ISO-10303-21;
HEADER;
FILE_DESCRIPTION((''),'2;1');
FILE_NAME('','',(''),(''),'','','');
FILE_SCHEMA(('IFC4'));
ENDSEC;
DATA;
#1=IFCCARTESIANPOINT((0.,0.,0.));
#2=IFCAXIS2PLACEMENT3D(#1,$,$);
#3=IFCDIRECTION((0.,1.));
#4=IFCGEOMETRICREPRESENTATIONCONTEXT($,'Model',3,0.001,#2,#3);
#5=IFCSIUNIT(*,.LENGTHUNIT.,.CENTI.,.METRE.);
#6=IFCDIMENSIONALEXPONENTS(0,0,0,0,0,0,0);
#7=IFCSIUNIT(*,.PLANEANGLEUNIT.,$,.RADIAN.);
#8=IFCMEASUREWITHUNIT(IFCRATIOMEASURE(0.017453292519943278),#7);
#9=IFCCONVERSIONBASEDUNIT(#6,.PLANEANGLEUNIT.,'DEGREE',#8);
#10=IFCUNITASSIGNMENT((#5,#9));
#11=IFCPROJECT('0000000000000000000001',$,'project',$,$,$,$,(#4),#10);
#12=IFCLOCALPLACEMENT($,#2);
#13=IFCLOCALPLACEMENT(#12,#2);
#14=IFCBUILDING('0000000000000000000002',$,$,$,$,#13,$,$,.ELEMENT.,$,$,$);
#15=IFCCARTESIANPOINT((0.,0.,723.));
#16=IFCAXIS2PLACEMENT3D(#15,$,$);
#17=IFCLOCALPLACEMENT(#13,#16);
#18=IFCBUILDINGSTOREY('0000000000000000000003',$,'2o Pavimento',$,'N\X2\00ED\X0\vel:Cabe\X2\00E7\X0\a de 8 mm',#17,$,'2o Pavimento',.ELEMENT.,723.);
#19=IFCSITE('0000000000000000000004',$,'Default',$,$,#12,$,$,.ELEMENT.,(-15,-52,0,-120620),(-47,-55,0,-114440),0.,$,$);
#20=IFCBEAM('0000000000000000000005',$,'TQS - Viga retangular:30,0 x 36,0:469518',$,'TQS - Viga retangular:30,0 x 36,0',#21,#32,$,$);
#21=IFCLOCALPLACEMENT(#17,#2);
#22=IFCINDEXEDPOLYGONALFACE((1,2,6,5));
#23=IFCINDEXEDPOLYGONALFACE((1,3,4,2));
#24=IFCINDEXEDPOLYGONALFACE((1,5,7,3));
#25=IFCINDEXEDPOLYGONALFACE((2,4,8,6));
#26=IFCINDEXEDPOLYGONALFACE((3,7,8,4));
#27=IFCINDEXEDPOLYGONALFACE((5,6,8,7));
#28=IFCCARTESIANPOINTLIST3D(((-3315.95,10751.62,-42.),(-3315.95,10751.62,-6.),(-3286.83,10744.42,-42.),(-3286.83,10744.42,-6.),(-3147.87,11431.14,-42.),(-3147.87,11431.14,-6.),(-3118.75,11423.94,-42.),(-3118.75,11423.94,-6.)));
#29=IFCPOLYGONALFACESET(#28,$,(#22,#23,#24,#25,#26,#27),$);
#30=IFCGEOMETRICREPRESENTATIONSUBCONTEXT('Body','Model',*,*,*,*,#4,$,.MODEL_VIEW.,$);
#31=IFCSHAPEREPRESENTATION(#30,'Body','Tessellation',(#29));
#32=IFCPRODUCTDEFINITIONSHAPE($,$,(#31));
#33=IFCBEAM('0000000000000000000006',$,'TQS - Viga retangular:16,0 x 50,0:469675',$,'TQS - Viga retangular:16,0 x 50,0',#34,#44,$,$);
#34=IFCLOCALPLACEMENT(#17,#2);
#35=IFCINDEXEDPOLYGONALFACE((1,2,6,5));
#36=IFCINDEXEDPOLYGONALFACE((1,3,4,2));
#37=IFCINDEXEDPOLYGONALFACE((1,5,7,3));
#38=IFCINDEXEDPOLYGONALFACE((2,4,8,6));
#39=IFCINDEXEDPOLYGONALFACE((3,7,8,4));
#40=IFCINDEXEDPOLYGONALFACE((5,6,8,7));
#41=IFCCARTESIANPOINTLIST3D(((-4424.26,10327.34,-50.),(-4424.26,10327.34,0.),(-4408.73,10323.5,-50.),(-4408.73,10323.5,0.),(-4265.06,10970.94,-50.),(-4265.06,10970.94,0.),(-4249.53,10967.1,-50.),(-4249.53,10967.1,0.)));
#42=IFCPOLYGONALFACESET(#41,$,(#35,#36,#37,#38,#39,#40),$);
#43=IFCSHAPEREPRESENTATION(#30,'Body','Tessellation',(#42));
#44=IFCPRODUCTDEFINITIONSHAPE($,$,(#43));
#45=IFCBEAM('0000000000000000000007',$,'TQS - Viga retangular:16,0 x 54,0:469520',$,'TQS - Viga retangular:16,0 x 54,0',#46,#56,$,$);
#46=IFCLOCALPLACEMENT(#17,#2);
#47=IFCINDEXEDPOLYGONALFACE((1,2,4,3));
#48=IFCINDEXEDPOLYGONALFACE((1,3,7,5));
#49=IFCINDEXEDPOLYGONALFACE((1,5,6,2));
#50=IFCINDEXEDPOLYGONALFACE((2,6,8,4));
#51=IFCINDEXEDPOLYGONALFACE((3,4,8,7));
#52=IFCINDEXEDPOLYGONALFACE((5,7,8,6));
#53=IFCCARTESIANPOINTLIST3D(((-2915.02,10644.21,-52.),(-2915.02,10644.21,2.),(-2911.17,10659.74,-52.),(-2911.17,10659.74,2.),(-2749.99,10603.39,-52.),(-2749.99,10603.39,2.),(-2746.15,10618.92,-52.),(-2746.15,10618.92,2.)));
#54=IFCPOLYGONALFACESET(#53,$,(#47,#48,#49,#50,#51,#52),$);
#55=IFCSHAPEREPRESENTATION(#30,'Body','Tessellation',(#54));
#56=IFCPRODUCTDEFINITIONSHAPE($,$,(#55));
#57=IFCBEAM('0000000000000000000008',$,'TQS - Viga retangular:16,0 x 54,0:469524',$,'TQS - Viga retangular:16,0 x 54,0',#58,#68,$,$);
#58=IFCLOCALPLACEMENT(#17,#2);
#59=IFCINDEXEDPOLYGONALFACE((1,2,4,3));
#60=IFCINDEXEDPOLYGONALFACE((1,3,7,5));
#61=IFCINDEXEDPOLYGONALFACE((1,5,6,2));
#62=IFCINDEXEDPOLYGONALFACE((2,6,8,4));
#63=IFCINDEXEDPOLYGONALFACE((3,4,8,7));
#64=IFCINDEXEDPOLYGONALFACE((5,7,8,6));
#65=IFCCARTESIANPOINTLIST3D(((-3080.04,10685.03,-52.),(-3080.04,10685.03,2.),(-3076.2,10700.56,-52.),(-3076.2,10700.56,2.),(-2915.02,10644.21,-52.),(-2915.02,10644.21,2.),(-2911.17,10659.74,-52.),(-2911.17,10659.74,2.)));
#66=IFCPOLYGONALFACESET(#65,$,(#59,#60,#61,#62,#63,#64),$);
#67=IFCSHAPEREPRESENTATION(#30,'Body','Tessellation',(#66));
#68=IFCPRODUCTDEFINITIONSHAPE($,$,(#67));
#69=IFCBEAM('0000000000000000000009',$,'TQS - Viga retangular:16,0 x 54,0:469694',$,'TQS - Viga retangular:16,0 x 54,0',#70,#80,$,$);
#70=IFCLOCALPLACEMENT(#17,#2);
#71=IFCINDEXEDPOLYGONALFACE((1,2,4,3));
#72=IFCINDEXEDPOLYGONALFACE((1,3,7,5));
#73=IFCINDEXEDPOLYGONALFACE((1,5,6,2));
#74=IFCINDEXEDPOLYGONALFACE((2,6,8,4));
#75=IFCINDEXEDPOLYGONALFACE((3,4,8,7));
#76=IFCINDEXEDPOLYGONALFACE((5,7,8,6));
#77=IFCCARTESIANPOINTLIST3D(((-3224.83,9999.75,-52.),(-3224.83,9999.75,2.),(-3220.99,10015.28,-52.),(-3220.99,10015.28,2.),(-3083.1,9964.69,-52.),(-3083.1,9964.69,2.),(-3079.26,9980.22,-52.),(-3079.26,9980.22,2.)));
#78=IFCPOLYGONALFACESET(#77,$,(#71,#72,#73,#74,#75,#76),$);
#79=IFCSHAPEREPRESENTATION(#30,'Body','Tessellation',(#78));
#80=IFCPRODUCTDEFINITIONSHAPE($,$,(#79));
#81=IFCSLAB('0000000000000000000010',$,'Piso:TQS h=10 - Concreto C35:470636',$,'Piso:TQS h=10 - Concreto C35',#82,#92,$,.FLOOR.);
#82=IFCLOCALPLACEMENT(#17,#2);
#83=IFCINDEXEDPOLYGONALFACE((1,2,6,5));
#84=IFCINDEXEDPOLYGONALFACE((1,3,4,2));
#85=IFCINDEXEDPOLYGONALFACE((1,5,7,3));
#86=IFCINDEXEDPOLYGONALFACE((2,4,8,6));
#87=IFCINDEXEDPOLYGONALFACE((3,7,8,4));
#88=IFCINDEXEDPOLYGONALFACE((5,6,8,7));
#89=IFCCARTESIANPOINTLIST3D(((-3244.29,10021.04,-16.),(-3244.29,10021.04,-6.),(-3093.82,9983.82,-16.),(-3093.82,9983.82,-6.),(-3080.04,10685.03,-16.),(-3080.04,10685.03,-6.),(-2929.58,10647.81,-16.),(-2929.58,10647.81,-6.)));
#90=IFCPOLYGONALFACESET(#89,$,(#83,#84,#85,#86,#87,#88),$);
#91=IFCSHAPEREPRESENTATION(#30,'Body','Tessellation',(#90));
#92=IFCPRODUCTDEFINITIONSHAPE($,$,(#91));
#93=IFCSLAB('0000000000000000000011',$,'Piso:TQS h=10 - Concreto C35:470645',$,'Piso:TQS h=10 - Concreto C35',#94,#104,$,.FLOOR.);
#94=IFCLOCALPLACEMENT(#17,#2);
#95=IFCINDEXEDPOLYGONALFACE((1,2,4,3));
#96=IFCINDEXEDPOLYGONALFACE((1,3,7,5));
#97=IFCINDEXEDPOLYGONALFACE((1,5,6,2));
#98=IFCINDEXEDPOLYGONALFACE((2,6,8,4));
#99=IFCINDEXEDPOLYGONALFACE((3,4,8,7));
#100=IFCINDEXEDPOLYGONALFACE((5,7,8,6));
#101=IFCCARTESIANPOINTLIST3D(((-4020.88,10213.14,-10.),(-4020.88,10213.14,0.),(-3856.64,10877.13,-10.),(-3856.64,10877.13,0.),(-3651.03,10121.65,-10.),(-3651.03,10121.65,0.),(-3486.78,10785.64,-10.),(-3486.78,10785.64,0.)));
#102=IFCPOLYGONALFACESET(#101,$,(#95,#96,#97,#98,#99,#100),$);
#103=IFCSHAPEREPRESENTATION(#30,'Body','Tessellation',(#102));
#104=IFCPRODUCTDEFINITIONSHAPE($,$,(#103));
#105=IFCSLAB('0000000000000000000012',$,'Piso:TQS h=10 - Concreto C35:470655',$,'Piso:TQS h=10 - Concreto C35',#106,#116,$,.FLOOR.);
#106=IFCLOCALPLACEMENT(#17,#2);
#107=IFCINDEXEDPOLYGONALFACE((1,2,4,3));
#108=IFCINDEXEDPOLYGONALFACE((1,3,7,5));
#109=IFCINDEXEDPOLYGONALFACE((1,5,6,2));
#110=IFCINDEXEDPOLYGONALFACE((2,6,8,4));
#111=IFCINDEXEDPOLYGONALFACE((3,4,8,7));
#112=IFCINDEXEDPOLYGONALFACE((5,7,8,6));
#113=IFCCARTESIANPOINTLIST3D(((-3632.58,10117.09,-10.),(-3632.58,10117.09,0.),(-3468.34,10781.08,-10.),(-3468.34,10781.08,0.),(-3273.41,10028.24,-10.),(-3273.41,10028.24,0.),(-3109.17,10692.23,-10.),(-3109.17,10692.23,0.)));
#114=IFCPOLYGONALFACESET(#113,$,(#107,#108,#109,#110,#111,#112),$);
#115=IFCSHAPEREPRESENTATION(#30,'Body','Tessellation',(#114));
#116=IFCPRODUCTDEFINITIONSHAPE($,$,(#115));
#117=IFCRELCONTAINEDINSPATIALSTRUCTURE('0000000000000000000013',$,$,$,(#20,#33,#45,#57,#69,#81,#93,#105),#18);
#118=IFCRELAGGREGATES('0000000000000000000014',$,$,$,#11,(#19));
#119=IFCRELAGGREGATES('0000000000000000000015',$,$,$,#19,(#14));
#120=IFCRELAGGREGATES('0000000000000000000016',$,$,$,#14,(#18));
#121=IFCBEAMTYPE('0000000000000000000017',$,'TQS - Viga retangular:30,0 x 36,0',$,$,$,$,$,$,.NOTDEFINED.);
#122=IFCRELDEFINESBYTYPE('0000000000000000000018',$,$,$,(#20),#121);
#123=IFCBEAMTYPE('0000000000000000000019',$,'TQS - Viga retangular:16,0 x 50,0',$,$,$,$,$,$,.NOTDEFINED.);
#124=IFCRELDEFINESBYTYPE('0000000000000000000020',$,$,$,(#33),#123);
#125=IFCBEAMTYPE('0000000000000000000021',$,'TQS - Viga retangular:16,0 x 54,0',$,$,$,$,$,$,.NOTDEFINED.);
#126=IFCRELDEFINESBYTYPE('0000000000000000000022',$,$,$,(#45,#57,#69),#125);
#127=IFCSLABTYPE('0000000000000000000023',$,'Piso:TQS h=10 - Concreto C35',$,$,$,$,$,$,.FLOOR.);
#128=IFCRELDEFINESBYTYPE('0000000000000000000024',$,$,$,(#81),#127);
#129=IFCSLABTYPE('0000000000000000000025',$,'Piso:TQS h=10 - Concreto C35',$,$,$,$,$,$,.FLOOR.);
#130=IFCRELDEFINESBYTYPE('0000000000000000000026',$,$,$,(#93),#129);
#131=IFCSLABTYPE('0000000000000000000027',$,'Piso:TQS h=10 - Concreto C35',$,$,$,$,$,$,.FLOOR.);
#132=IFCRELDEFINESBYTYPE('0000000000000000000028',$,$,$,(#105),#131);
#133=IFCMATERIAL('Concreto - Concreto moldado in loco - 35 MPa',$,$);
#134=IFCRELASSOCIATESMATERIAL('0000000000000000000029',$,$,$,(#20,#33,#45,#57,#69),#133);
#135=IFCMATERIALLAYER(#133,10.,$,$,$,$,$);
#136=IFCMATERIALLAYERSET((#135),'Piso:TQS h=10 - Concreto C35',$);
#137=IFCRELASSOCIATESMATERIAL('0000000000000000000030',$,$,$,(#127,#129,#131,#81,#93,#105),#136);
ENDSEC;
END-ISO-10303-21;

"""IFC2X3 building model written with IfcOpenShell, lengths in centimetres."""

from ifc_helpers import new_model, entity, si_unit, converted_unit, direction, frame, frame_2d, origin, place, context, subcontext, project, spatial, rectangle, extrude, material, layer, layer_set, layer_usage, type_object, element, save


model = new_model("IFC2X3")

# Units and contexts
model_context = context("Model", 3, precision=0.001, world=origin(), true_north=direction((0.0, 1.0)))
body_context = subcontext(model_context, "Body", "Model", "MODEL_VIEW")
ifc_project = project(units=[si_unit("LENGTHUNIT", "METRE", prefix="CENTI"), converted_unit("PLANEANGLEUNIT", "DEGREE", entity("IfcRatioMeasure", 0.017453292519943278), si_unit("PLANEANGLEUNIT", "RADIAN"), dimensions=[0, 0, 0, 0, 0, 0, 0])], contexts=[model_context])

# Site, building, storey
site_placement = place(None, origin())
site = spatial("IfcSite", under=ifc_project, at=site_placement, Name="Default", CompositionType="ELEMENT", RefLatitude=(-15, -52, 0, -120620), RefLongitude=(-47, -55, 0, -114440), RefElevation=0.0)
building_placement = place(site_placement, origin())
building = spatial("IfcBuilding", under=site, at=building_placement, CompositionType="ELEMENT")
storey_placement = place(building_placement, frame((0.0, 0.0, 723.0)))
storey = spatial("IfcBuildingStorey", under=building, at=storey_placement, Name="2o Pavimento", ObjectType="Nível:Cabeça de 8 mm", LongName="2o Pavimento", CompositionType="ELEMENT", Elevation=723.0)

# Beams
ifc_material = material(Name="Concreto - Concreto moldado in loco - 35 MPa")
beam_type_1 = type_object("IfcBeamType", Name="TQS - Viga retangular:30,0 x 36,0", PredefinedType="NOTDEFINED")
beam_1_placement = place(storey_placement, frame((-3301.39, 10748.02, -6.0), z_axis=(0.0, 0.0, 1.0), x_axis=(0.240122, 0.970743, 0.0)))
element("IfcBeam", 1, at=beam_1_placement, inside=storey, type_object=beam_type_1, material=ifc_material, Name="TQS - Viga retangular:30,0 x 36,0:469518", ObjectType="TQS - Viga retangular:30,0 x 36,0", context=body_context, shape_type="SweptSolid", body=[
    extrude(rectangle(XDim=36.0, YDim=30.0, at=frame_2d((0.0, 0.0), x_axis=(1.0, 0.0))), frame((0.0, 0.0, -18.0), z_axis=(1.0, 0.0, 0.0), x_axis=(0.0, 0.0, -1.0)), (0.0, 0.0, 1.0), 700.0),
])
beam_type_2 = type_object("IfcBeamType", Name="TQS - Viga retangular:16,0 x 50,0", PredefinedType="NOTDEFINED")
beam_2_placement = place(storey_placement, frame((-4416.49, 10325.42, 0.0), z_axis=(0.0, 0.0, 1.0), x_axis=(0.240122, 0.970743, 0.0)))
element("IfcBeam", 2, at=beam_2_placement, inside=storey, type_object=beam_type_2, material=ifc_material, Name="TQS - Viga retangular:16,0 x 50,0:469675", ObjectType="TQS - Viga retangular:16,0 x 50,0", context=body_context, shape_type="SweptSolid", body=[
    extrude(rectangle(XDim=50.0, YDim=16.0, at=frame_2d((0.0, 0.0), x_axis=(1.0, 0.0))), frame((0.0, 0.0, -25.0), z_axis=(1.0, 0.0, 0.0), x_axis=(0.0, 0.0, -1.0)), (0.0, 0.0, 1.0), 663.0),
])
beam_type_3 = type_object("IfcBeamType", Name="TQS - Viga retangular:16,0 x 54,0", PredefinedType="NOTDEFINED")
beam_3_placement = place(storey_placement, frame((-2748.07, 10611.15, 2.0), z_axis=(0.0, 0.0, 1.0), x_axis=(-0.970743, 0.240122, 0.0)))
element("IfcBeam", 3, at=beam_3_placement, inside=storey, type_object=beam_type_3, material=ifc_material, Name="TQS - Viga retangular:16,0 x 54,0:469520", ObjectType="TQS - Viga retangular:16,0 x 54,0", context=body_context, shape_type="SweptSolid", body=[
    extrude(rectangle(XDim=54.0, YDim=16.0, at=frame_2d((0.0, 0.0), x_axis=(1.0, 0.0))), frame((0.0, 0.0, -27.0), z_axis=(1.0, 0.0, 0.0), x_axis=(0.0, 0.0, -1.0)), (0.0, 0.0, 1.0), 170.0),
])
beam_4_placement = place(storey_placement, frame((-2913.1, 10651.97, 2.0), z_axis=(0.0, 0.0, 1.0), x_axis=(-0.970743, 0.240122, 0.0)))
element("IfcBeam", 4, at=beam_4_placement, inside=storey, type_object=beam_type_3, material=ifc_material, Name="TQS - Viga retangular:16,0 x 54,0:469524", ObjectType="TQS - Viga retangular:16,0 x 54,0", context=body_context, shape_type="SweptSolid", body=[
    extrude(rectangle(XDim=54.0, YDim=16.0, at=frame_2d((0.0, 0.0), x_axis=(1.0, 0.0))), frame((0.0, 0.0, -27.0), z_axis=(1.0, 0.0, 0.0), x_axis=(0.0, 0.0, -1.0)), (0.0, 0.0, 1.0), 170.0),
])
beam_5_placement = place(storey_placement, frame((-3081.18, 9972.45, 2.0), z_axis=(0.0, 0.0, 1.0), x_axis=(-0.970743, 0.240122, 0.0)))
element("IfcBeam", 5, at=beam_5_placement, inside=storey, type_object=beam_type_3, material=ifc_material, Name="TQS - Viga retangular:16,0 x 54,0:469694", ObjectType="TQS - Viga retangular:16,0 x 54,0", context=body_context, shape_type="SweptSolid", body=[
    extrude(rectangle(XDim=54.0, YDim=16.0, at=frame_2d((0.0, 0.0), x_axis=(1.0, 0.0))), frame((0.0, 0.0, -27.0), z_axis=(1.0, 0.0, 0.0), x_axis=(0.0, 0.0, -1.0)), (0.0, 0.0, 1.0), 146.0),
])

# Slabs
ifc_layer = layer(ifc_material, 10.0)
ifc_layer_set = layer_set([ifc_layer], Name="Piso:TQS h=10 - Concreto C35")
ifc_layer_usage_1 = layer_usage(ifc_layer_set, "AXIS3", "POSITIVE", 0.0)
slab_type_1 = type_object("IfcSlabType", Name="Piso:TQS h=10 - Concreto C35", PredefinedType="FLOOR", material=ifc_layer_set)
slab_1_placement = place(storey_placement, origin())
element("IfcSlab", 6, at=slab_1_placement, inside=storey, type_object=slab_type_1, material=ifc_layer_usage_1, Name="Piso:TQS h=10 - Concreto C35:470636", ObjectType="Piso:TQS h=10 - Concreto C35", PredefinedType="FLOOR", context=body_context, shape_type="SweptSolid", body=[
    extrude(rectangle(XDim=155.0, YDim=684.0, at=frame_2d((0.0, 0.0), x_axis=(1.0, 0.0))), frame((-3086.93, 10334.43, -6.0), z_axis=(0.0, 0.0, -1.0), x_axis=(0.970743, -0.240122, 0.0)), (0.0, 0.0, 1.0), 10.0),
])
ifc_layer_usage_2 = layer_usage(ifc_layer_set, "AXIS3", "POSITIVE", 0.0)
slab_type_2 = type_object("IfcSlabType", Name="Piso:TQS h=10 - Concreto C35", PredefinedType="FLOOR", material=ifc_layer_set)
slab_2_placement = place(storey_placement, origin())
element("IfcSlab", 7, at=slab_2_placement, inside=storey, type_object=slab_type_2, material=ifc_layer_usage_2, Name="Piso:TQS h=10 - Concreto C35:470645", ObjectType="Piso:TQS h=10 - Concreto C35", PredefinedType="FLOOR", context=body_context, shape_type="SweptSolid", body=[
    extrude(rectangle(XDim=381.0, YDim=684.0, at=frame_2d((0.0, 0.0), x_axis=(1.0, 0.0))), frame((-3753.83, 10499.39, 0.0), z_axis=(0.0, 0.0, -1.0), x_axis=(0.970743, -0.240122, 0.0)), (0.0, 0.0, 1.0), 10.0),
])
ifc_layer_usage_3 = layer_usage(ifc_layer_set, "AXIS3", "POSITIVE", 0.0)
slab_type_3 = type_object("IfcSlabType", Name="Piso:TQS h=10 - Concreto C35", PredefinedType="FLOOR", material=ifc_layer_set)
slab_3_placement = place(storey_placement, origin())
element("IfcSlab", 8, at=slab_3_placement, inside=storey, type_object=slab_type_3, material=ifc_layer_usage_3, Name="Piso:TQS h=10 - Concreto C35:470655", ObjectType="Piso:TQS h=10 - Concreto C35", PredefinedType="FLOOR", context=body_context, shape_type="SweptSolid", body=[
    extrude(rectangle(XDim=370.0, YDim=684.0, at=frame_2d((0.0, 0.0), x_axis=(1.0, 0.0))), frame((-3370.87, 10404.66, 0.0), z_axis=(0.0, 0.0, -1.0), x_axis=(0.970743, -0.240122, 0.0)), (0.0, 0.0, 1.0), 10.0),
])

save(model, "model.ifc")
